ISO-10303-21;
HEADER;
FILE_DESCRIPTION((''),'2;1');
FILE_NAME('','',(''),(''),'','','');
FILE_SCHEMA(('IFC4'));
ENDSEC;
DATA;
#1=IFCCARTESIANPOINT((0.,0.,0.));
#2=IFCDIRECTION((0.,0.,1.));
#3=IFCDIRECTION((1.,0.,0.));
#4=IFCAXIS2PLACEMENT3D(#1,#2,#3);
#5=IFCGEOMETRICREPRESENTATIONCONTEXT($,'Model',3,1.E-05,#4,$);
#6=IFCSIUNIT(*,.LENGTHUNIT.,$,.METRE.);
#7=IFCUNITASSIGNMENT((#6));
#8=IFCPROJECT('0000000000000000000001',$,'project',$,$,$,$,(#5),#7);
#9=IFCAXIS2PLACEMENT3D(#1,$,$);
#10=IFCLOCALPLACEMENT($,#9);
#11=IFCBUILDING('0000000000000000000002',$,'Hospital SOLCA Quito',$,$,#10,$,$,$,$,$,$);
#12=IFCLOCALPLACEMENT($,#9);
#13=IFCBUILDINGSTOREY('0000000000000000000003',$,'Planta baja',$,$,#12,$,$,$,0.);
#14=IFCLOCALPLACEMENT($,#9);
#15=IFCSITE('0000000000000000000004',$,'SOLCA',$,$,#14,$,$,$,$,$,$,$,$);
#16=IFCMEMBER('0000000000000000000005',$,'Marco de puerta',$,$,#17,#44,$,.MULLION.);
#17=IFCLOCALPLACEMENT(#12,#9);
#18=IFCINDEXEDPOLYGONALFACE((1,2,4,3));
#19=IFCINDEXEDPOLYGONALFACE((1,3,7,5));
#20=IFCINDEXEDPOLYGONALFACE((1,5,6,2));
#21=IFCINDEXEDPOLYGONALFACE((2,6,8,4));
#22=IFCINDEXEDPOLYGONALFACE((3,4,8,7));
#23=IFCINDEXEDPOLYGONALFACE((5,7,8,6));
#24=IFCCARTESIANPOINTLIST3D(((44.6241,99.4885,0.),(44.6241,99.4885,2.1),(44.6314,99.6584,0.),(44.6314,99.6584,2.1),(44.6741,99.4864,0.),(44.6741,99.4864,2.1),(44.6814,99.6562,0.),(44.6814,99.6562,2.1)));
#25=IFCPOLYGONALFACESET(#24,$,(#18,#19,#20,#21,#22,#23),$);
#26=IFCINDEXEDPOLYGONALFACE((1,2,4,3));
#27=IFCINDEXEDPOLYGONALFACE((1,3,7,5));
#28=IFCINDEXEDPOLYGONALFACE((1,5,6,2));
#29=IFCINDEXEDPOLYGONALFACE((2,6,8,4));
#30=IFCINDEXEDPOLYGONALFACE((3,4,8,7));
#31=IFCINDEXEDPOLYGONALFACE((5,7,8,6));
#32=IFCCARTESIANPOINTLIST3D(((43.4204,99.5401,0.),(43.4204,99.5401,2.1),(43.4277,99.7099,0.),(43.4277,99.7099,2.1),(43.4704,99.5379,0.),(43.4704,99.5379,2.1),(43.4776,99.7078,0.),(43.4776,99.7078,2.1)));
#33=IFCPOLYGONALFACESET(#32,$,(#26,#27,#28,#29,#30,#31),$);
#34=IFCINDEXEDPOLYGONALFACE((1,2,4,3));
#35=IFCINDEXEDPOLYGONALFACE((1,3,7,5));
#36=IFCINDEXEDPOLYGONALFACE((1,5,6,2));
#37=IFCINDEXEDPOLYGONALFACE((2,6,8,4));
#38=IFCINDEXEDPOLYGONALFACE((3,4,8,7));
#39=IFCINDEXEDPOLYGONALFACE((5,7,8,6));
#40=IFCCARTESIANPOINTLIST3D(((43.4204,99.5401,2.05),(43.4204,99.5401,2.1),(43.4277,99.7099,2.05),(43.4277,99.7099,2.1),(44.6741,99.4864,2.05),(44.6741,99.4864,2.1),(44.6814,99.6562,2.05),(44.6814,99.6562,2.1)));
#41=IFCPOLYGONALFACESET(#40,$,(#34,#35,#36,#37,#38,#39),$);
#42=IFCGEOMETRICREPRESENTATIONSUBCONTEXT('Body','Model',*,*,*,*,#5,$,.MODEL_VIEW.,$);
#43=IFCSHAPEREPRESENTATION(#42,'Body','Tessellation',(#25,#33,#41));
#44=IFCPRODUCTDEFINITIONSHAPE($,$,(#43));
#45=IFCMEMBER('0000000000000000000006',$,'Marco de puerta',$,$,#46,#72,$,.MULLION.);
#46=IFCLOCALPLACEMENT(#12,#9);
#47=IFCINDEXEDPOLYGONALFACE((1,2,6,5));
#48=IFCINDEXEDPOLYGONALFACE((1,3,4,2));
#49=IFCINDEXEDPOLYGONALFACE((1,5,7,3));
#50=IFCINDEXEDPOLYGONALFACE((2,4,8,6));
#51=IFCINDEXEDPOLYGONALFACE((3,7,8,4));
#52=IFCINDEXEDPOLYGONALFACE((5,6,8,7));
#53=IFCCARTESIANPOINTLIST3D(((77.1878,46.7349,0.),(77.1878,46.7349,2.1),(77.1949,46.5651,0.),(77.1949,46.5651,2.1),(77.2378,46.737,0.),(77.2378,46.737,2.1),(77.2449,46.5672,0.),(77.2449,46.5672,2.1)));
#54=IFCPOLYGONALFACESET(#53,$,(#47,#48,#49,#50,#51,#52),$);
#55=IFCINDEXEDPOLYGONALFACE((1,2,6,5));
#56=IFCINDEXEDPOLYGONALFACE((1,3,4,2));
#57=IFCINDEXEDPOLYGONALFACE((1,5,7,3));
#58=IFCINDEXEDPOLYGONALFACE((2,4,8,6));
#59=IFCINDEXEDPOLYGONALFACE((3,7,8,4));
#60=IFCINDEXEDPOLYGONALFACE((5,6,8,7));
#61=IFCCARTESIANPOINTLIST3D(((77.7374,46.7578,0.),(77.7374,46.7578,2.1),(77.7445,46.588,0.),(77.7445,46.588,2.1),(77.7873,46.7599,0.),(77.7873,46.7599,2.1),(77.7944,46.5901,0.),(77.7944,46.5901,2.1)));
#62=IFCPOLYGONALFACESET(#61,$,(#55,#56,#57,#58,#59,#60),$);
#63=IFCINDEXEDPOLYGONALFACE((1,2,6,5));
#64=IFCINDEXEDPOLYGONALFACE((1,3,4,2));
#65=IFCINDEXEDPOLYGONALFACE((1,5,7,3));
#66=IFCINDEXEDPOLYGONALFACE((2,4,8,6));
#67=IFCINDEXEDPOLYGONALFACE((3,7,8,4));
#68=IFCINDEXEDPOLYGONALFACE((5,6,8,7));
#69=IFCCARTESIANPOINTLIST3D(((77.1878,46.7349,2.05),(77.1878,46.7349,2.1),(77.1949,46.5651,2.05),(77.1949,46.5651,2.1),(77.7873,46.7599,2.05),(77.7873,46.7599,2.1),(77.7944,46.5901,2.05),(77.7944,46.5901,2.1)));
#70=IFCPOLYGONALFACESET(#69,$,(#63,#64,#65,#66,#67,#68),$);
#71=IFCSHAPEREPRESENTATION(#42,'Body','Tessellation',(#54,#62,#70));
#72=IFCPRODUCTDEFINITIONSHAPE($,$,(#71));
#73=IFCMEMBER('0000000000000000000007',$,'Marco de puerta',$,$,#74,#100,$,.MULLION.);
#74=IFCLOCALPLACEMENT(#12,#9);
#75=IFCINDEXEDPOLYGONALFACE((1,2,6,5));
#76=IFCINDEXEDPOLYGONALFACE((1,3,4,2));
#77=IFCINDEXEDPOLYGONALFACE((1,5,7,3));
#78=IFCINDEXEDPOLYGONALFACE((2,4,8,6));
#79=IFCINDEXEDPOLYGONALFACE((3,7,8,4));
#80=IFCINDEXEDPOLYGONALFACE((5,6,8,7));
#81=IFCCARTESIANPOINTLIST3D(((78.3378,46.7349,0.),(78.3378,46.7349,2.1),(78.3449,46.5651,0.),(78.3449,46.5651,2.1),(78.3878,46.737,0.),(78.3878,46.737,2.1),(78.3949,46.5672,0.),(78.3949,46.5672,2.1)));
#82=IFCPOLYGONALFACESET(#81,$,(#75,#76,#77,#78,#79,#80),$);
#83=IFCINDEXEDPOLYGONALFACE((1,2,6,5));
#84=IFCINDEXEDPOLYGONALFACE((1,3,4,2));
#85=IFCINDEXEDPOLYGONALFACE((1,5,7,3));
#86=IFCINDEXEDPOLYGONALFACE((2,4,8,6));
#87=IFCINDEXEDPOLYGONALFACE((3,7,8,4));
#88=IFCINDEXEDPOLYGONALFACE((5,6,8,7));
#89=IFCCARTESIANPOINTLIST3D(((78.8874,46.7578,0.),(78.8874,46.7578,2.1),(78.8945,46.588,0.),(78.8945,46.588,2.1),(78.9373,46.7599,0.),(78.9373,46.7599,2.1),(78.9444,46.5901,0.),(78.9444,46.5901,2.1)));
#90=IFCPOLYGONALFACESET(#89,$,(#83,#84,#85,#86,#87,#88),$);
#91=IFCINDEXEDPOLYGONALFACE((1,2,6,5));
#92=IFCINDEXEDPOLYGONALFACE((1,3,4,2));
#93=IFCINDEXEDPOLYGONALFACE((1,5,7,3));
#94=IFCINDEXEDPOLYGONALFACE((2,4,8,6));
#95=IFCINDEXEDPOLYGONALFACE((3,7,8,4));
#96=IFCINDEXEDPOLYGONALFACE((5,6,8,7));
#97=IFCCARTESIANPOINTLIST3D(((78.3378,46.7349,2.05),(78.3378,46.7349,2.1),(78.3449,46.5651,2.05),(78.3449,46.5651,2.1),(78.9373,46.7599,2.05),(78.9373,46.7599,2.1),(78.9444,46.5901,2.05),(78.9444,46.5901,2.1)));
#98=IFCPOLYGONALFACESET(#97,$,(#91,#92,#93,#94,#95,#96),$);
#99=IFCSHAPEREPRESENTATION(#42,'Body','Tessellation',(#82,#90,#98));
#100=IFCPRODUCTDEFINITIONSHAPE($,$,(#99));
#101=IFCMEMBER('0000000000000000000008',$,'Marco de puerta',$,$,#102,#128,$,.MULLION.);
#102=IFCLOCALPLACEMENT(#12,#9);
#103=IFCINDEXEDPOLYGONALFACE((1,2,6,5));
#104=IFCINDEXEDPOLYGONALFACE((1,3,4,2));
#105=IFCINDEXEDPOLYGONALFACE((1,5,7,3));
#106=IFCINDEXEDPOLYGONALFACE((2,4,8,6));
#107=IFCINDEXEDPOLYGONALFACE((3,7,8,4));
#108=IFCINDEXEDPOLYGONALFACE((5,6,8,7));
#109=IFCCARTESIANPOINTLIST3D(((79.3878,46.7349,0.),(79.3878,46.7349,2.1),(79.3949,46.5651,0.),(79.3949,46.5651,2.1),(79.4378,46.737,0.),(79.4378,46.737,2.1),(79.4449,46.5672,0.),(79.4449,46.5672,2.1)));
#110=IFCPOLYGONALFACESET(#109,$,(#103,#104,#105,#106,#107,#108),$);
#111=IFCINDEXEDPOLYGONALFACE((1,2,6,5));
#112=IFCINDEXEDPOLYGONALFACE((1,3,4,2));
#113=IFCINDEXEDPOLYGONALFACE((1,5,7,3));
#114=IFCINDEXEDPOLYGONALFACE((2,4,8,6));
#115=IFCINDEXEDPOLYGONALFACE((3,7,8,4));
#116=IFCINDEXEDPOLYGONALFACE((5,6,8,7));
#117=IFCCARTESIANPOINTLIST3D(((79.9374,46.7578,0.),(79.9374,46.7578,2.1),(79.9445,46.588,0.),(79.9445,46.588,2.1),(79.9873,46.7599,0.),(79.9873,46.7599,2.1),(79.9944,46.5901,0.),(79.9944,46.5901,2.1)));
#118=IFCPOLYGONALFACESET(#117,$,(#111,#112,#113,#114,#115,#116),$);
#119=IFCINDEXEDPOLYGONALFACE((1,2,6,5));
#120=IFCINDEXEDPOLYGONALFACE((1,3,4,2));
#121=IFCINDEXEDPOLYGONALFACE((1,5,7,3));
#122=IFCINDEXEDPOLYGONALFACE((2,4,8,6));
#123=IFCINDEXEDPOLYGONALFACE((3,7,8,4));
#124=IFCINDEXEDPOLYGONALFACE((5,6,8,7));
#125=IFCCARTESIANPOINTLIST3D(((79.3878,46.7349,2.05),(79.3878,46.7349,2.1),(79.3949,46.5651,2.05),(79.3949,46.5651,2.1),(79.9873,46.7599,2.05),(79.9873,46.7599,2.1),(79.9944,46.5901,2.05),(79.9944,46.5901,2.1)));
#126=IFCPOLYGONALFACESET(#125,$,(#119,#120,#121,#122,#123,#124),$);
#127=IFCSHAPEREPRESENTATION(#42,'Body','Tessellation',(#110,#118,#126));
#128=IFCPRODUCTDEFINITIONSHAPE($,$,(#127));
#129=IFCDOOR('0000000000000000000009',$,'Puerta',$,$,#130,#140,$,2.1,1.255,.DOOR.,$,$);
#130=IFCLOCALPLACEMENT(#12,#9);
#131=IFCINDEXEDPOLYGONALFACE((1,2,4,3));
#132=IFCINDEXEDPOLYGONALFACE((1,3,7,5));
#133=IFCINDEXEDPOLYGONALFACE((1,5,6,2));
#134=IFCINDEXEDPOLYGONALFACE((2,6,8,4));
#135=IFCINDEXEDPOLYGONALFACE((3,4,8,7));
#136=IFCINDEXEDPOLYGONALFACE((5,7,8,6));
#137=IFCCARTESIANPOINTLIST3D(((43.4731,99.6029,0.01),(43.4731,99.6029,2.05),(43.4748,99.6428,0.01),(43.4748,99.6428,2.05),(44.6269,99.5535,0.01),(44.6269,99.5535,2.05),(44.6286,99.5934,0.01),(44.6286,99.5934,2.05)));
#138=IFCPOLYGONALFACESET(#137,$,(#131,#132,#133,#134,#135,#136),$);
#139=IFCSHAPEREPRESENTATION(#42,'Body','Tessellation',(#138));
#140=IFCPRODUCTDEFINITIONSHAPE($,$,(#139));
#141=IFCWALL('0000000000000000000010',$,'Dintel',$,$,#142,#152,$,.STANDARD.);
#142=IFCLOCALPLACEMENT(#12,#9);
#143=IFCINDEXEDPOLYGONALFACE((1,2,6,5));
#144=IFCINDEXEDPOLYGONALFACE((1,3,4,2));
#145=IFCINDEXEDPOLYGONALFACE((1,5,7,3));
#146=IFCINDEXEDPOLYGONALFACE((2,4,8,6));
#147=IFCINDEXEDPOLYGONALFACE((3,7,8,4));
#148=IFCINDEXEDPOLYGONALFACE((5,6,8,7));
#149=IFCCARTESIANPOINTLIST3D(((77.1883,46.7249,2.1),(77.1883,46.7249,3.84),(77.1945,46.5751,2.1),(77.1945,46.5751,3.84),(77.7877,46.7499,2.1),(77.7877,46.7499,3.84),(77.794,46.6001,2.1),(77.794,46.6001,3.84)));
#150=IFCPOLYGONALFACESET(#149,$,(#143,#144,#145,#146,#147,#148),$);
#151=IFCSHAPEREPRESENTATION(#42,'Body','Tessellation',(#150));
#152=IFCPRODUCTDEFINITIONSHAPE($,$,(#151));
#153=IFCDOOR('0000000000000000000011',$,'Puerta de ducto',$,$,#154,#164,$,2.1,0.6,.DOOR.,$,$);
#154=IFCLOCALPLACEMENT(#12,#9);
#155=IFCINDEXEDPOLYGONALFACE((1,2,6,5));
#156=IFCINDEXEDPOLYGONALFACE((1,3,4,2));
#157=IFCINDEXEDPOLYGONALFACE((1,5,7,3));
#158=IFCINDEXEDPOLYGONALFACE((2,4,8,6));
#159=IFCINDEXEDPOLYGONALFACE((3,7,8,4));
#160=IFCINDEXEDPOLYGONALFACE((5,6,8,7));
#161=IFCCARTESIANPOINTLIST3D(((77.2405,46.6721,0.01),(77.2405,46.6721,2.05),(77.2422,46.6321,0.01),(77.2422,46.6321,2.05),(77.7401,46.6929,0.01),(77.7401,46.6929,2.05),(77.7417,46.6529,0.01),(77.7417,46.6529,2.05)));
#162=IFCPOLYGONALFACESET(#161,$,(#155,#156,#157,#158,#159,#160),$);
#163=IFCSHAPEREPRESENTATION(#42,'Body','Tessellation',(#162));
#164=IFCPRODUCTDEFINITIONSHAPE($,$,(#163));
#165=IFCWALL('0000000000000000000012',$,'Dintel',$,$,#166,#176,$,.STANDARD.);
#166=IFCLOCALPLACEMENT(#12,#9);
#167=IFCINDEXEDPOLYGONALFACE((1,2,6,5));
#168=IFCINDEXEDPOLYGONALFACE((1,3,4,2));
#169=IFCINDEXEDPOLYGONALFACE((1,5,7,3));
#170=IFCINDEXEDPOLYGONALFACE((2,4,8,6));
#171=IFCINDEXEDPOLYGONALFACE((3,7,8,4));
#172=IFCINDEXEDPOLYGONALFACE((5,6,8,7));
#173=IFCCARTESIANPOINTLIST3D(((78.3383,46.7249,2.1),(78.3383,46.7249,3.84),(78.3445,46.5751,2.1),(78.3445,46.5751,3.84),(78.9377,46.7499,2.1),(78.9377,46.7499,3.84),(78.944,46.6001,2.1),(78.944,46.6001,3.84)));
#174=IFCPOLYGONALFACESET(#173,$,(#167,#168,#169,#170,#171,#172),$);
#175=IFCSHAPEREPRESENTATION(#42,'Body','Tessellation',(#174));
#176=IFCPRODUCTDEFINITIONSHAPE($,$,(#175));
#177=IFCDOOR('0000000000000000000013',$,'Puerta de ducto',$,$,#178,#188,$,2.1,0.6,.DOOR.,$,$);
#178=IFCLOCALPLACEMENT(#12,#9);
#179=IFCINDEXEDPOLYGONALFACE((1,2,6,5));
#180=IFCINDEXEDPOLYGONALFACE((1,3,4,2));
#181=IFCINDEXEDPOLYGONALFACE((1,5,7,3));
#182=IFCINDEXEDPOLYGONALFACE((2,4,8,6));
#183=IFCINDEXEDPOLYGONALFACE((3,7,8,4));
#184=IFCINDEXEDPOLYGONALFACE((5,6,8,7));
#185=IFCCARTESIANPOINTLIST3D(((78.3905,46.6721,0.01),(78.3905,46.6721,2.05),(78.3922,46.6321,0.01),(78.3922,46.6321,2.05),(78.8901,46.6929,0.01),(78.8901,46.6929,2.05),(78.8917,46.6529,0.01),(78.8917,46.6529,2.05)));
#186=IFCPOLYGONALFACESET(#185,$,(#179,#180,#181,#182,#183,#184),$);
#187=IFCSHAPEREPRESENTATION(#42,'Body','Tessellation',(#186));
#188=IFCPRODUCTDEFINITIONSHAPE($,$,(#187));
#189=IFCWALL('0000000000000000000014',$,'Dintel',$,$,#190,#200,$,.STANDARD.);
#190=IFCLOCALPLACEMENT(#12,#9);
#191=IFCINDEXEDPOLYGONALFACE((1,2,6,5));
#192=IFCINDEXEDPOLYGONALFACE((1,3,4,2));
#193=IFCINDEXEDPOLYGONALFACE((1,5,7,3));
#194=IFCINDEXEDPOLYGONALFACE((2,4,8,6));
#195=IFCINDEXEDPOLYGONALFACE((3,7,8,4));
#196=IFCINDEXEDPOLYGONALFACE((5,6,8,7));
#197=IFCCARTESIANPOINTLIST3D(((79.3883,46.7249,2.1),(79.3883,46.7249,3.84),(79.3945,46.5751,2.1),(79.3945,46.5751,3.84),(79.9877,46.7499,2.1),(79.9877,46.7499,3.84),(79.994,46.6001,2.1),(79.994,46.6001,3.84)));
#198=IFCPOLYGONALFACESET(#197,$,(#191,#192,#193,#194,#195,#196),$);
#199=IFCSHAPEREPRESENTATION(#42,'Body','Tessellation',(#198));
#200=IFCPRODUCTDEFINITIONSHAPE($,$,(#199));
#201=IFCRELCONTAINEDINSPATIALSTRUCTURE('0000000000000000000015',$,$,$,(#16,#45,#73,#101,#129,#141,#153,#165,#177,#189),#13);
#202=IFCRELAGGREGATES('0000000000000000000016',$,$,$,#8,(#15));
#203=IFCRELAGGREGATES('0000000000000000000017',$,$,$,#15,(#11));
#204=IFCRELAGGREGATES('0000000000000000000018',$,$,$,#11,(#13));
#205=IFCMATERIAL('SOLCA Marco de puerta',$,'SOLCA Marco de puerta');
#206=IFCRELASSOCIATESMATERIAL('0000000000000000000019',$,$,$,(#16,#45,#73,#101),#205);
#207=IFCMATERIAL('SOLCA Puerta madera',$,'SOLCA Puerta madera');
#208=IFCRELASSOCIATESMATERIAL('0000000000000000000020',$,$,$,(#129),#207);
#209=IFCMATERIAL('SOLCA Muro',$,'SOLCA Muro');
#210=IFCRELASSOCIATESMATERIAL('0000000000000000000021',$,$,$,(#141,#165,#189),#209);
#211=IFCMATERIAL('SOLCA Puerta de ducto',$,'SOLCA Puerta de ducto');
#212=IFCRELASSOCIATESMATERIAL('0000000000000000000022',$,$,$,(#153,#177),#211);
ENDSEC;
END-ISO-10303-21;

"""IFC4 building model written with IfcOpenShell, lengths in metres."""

from ifc_helpers import new_model, si_unit, frame, origin, origin_with_axes, place, context, subcontext, project, spatial, polyline, outline, extrude, material, element, save


model = new_model("IFC4")

# Units and contexts
model_context = context("Model", 3, precision=1e-05, world=origin_with_axes())
body_context = subcontext(model_context, "Body", "Model", "MODEL_VIEW")
ifc_project = project(units=[si_unit("LENGTHUNIT", "METRE")], contexts=[model_context])

# Site, building, storey
site_placement = place(None, origin())
site = spatial("IfcSite", under=ifc_project, at=site_placement, Name="SOLCA")
building_placement = place(None, origin())
building = spatial("IfcBuilding", under=site, at=building_placement, Name="Hospital SOLCA Quito")
storey_placement = place(None, origin())
storey = spatial("IfcBuildingStorey", under=building, at=storey_placement, Name="Planta baja", Elevation=0.0)

# Members
ifc_material_1 = material(Name="SOLCA Marco de puerta", Category="SOLCA Marco de puerta")
member_1_placement = place(storey_placement, origin_with_axes())
element("IfcMember", 1, at=member_1_placement, inside=storey, material=ifc_material_1, Name="Marco de puerta", PredefinedType="MULLION", context=body_context, shape_type="SweptSolid", body=[
    extrude(outline(polyline([(44.6814, 99.6562), (44.6314, 99.6584), (44.6241, 99.4885), (44.6741, 99.4864), (44.6814, 99.6562)])), origin_with_axes(), (0.0, 0.0, 1.0), 2.1),
    extrude(outline(polyline([(43.4776, 99.7078), (43.4277, 99.7099), (43.4204, 99.5401), (43.4704, 99.5379), (43.4776, 99.7078)])), origin_with_axes(), (0.0, 0.0, 1.0), 2.1),
    extrude(outline(polyline([(44.6814, 99.6562), (43.4277, 99.7099), (43.4204, 99.5401), (44.6741, 99.4864), (44.6814, 99.6562)])), frame((0.0, 0.0, 2.05), z_axis=(0.0, 0.0, 1.0), x_axis=(1.0, 0.0, 0.0)), (0.0, 0.0, 1.0), 0.05),
])
member_2_placement = place(storey_placement, origin_with_axes())
element("IfcMember", 2, at=member_2_placement, inside=storey, material=ifc_material_1, Name="Marco de puerta", PredefinedType="MULLION", context=body_context, shape_type="SweptSolid", body=[
    extrude(outline(polyline([(77.1949, 46.5651), (77.2449, 46.5672), (77.2378, 46.737), (77.1878, 46.7349), (77.1949, 46.5651)])), origin_with_axes(), (0.0, 0.0, 1.0), 2.1),
    extrude(outline(polyline([(77.7445, 46.588), (77.7944, 46.5901), (77.7873, 46.7599), (77.7374, 46.7578), (77.7445, 46.588)])), origin_with_axes(), (0.0, 0.0, 1.0), 2.1),
    extrude(outline(polyline([(77.1949, 46.5651), (77.7944, 46.5901), (77.7873, 46.7599), (77.1878, 46.7349), (77.1949, 46.5651)])), frame((0.0, 0.0, 2.05), z_axis=(0.0, 0.0, 1.0), x_axis=(1.0, 0.0, 0.0)), (0.0, 0.0, 1.0), 0.05),
])
member_3_placement = place(storey_placement, origin_with_axes())
element("IfcMember", 3, at=member_3_placement, inside=storey, material=ifc_material_1, Name="Marco de puerta", PredefinedType="MULLION", context=body_context, shape_type="SweptSolid", body=[
    extrude(outline(polyline([(78.3449, 46.5651), (78.3949, 46.5672), (78.3878, 46.737), (78.3378, 46.7349), (78.3449, 46.5651)])), origin_with_axes(), (0.0, 0.0, 1.0), 2.1),
    extrude(outline(polyline([(78.8945, 46.588), (78.9444, 46.5901), (78.9373, 46.7599), (78.8874, 46.7578), (78.8945, 46.588)])), origin_with_axes(), (0.0, 0.0, 1.0), 2.1),
    extrude(outline(polyline([(78.3449, 46.5651), (78.9444, 46.5901), (78.9373, 46.7599), (78.3378, 46.7349), (78.3449, 46.5651)])), frame((0.0, 0.0, 2.05), z_axis=(0.0, 0.0, 1.0), x_axis=(1.0, 0.0, 0.0)), (0.0, 0.0, 1.0), 0.05),
])
member_4_placement = place(storey_placement, origin_with_axes())
element("IfcMember", 4, at=member_4_placement, inside=storey, material=ifc_material_1, Name="Marco de puerta", PredefinedType="MULLION", context=body_context, shape_type="SweptSolid", body=[
    extrude(outline(polyline([(79.3949, 46.5651), (79.4449, 46.5672), (79.4378, 46.737), (79.3878, 46.7349), (79.3949, 46.5651)])), origin_with_axes(), (0.0, 0.0, 1.0), 2.1),
    extrude(outline(polyline([(79.9445, 46.588), (79.9944, 46.5901), (79.9873, 46.7599), (79.9374, 46.7578), (79.9445, 46.588)])), origin_with_axes(), (0.0, 0.0, 1.0), 2.1),
    extrude(outline(polyline([(79.3949, 46.5651), (79.9944, 46.5901), (79.9873, 46.7599), (79.3878, 46.7349), (79.3949, 46.5651)])), frame((0.0, 0.0, 2.05), z_axis=(0.0, 0.0, 1.0), x_axis=(1.0, 0.0, 0.0)), (0.0, 0.0, 1.0), 0.05),
])

# Door
ifc_material_2 = material(Name="SOLCA Puerta madera", Category="SOLCA Puerta madera")
door_1_placement = place(storey_placement, origin_with_axes())
element("IfcDoor", 5, at=door_1_placement, inside=storey, material=ifc_material_2, Name="Puerta", OverallHeight=2.1, OverallWidth=1.255, PredefinedType="DOOR", context=body_context, shape_type="SweptSolid", body=[
    extrude(outline(polyline([(44.6286, 99.5934), (43.4748, 99.6428), (43.4731, 99.6029), (44.6269, 99.5535), (44.6286, 99.5934)])), frame((0.0, 0.0, 0.01), z_axis=(0.0, 0.0, 1.0), x_axis=(1.0, 0.0, 0.0)), (0.0, 0.0, 1.0), 2.04),
])

# Wall
ifc_material_3 = material(Name="SOLCA Muro", Category="SOLCA Muro")
wall_1_placement = place(storey_placement, origin_with_axes())
element("IfcWall", 6, at=wall_1_placement, inside=storey, material=ifc_material_3, Name="Dintel", PredefinedType="STANDARD", context=body_context, shape_type="SweptSolid", body=[
    extrude(outline(polyline([(77.1945, 46.5751), (77.794, 46.6001), (77.7877, 46.7499), (77.1883, 46.7249), (77.1945, 46.5751)])), frame((0.0, 0.0, 2.1), z_axis=(0.0, 0.0, 1.0), x_axis=(1.0, 0.0, 0.0)), (0.0, 0.0, 1.0), 1.74),
])

# Door
ifc_material_4 = material(Name="SOLCA Puerta de ducto", Category="SOLCA Puerta de ducto")
door_2_placement = place(storey_placement, origin_with_axes())
element("IfcDoor", 7, at=door_2_placement, inside=storey, material=ifc_material_4, Name="Puerta de ducto", OverallHeight=2.1, OverallWidth=0.6, PredefinedType="DOOR", context=body_context, shape_type="SweptSolid", body=[
    extrude(outline(polyline([(77.2422, 46.6321), (77.7417, 46.6529), (77.7401, 46.6929), (77.2405, 46.6721), (77.2422, 46.6321)])), frame((0.0, 0.0, 0.01), z_axis=(0.0, 0.0, 1.0), x_axis=(1.0, 0.0, 0.0)), (0.0, 0.0, 1.0), 2.04),
])

# Wall
wall_2_placement = place(storey_placement, origin_with_axes())
element("IfcWall", 8, at=wall_2_placement, inside=storey, material=ifc_material_3, Name="Dintel", PredefinedType="STANDARD", context=body_context, shape_type="SweptSolid", body=[
    extrude(outline(polyline([(78.3445, 46.5751), (78.944, 46.6001), (78.9377, 46.7499), (78.3383, 46.7249), (78.3445, 46.5751)])), frame((0.0, 0.0, 2.1), z_axis=(0.0, 0.0, 1.0), x_axis=(1.0, 0.0, 0.0)), (0.0, 0.0, 1.0), 1.74),
])

# Door
door_3_placement = place(storey_placement, origin_with_axes())
element("IfcDoor", 9, at=door_3_placement, inside=storey, material=ifc_material_4, Name="Puerta de ducto", OverallHeight=2.1, OverallWidth=0.6, PredefinedType="DOOR", context=body_context, shape_type="SweptSolid", body=[
    extrude(outline(polyline([(78.3922, 46.6321), (78.8917, 46.6529), (78.8901, 46.6929), (78.3905, 46.6721), (78.3922, 46.6321)])), frame((0.0, 0.0, 0.01), z_axis=(0.0, 0.0, 1.0), x_axis=(1.0, 0.0, 0.0)), (0.0, 0.0, 1.0), 2.04),
])

# Wall
wall_3_placement = place(storey_placement, origin_with_axes())
element("IfcWall", 10, at=wall_3_placement, inside=storey, material=ifc_material_3, Name="Dintel", PredefinedType="STANDARD", context=body_context, shape_type="SweptSolid", body=[
    extrude(outline(polyline([(79.3945, 46.5751), (79.994, 46.6001), (79.9877, 46.7499), (79.3883, 46.7249), (79.3945, 46.5751)])), frame((0.0, 0.0, 2.1), z_axis=(0.0, 0.0, 1.0), x_axis=(1.0, 0.0, 0.0)), (0.0, 0.0, 1.0), 1.74),
])

save(model, "model.ifc")
